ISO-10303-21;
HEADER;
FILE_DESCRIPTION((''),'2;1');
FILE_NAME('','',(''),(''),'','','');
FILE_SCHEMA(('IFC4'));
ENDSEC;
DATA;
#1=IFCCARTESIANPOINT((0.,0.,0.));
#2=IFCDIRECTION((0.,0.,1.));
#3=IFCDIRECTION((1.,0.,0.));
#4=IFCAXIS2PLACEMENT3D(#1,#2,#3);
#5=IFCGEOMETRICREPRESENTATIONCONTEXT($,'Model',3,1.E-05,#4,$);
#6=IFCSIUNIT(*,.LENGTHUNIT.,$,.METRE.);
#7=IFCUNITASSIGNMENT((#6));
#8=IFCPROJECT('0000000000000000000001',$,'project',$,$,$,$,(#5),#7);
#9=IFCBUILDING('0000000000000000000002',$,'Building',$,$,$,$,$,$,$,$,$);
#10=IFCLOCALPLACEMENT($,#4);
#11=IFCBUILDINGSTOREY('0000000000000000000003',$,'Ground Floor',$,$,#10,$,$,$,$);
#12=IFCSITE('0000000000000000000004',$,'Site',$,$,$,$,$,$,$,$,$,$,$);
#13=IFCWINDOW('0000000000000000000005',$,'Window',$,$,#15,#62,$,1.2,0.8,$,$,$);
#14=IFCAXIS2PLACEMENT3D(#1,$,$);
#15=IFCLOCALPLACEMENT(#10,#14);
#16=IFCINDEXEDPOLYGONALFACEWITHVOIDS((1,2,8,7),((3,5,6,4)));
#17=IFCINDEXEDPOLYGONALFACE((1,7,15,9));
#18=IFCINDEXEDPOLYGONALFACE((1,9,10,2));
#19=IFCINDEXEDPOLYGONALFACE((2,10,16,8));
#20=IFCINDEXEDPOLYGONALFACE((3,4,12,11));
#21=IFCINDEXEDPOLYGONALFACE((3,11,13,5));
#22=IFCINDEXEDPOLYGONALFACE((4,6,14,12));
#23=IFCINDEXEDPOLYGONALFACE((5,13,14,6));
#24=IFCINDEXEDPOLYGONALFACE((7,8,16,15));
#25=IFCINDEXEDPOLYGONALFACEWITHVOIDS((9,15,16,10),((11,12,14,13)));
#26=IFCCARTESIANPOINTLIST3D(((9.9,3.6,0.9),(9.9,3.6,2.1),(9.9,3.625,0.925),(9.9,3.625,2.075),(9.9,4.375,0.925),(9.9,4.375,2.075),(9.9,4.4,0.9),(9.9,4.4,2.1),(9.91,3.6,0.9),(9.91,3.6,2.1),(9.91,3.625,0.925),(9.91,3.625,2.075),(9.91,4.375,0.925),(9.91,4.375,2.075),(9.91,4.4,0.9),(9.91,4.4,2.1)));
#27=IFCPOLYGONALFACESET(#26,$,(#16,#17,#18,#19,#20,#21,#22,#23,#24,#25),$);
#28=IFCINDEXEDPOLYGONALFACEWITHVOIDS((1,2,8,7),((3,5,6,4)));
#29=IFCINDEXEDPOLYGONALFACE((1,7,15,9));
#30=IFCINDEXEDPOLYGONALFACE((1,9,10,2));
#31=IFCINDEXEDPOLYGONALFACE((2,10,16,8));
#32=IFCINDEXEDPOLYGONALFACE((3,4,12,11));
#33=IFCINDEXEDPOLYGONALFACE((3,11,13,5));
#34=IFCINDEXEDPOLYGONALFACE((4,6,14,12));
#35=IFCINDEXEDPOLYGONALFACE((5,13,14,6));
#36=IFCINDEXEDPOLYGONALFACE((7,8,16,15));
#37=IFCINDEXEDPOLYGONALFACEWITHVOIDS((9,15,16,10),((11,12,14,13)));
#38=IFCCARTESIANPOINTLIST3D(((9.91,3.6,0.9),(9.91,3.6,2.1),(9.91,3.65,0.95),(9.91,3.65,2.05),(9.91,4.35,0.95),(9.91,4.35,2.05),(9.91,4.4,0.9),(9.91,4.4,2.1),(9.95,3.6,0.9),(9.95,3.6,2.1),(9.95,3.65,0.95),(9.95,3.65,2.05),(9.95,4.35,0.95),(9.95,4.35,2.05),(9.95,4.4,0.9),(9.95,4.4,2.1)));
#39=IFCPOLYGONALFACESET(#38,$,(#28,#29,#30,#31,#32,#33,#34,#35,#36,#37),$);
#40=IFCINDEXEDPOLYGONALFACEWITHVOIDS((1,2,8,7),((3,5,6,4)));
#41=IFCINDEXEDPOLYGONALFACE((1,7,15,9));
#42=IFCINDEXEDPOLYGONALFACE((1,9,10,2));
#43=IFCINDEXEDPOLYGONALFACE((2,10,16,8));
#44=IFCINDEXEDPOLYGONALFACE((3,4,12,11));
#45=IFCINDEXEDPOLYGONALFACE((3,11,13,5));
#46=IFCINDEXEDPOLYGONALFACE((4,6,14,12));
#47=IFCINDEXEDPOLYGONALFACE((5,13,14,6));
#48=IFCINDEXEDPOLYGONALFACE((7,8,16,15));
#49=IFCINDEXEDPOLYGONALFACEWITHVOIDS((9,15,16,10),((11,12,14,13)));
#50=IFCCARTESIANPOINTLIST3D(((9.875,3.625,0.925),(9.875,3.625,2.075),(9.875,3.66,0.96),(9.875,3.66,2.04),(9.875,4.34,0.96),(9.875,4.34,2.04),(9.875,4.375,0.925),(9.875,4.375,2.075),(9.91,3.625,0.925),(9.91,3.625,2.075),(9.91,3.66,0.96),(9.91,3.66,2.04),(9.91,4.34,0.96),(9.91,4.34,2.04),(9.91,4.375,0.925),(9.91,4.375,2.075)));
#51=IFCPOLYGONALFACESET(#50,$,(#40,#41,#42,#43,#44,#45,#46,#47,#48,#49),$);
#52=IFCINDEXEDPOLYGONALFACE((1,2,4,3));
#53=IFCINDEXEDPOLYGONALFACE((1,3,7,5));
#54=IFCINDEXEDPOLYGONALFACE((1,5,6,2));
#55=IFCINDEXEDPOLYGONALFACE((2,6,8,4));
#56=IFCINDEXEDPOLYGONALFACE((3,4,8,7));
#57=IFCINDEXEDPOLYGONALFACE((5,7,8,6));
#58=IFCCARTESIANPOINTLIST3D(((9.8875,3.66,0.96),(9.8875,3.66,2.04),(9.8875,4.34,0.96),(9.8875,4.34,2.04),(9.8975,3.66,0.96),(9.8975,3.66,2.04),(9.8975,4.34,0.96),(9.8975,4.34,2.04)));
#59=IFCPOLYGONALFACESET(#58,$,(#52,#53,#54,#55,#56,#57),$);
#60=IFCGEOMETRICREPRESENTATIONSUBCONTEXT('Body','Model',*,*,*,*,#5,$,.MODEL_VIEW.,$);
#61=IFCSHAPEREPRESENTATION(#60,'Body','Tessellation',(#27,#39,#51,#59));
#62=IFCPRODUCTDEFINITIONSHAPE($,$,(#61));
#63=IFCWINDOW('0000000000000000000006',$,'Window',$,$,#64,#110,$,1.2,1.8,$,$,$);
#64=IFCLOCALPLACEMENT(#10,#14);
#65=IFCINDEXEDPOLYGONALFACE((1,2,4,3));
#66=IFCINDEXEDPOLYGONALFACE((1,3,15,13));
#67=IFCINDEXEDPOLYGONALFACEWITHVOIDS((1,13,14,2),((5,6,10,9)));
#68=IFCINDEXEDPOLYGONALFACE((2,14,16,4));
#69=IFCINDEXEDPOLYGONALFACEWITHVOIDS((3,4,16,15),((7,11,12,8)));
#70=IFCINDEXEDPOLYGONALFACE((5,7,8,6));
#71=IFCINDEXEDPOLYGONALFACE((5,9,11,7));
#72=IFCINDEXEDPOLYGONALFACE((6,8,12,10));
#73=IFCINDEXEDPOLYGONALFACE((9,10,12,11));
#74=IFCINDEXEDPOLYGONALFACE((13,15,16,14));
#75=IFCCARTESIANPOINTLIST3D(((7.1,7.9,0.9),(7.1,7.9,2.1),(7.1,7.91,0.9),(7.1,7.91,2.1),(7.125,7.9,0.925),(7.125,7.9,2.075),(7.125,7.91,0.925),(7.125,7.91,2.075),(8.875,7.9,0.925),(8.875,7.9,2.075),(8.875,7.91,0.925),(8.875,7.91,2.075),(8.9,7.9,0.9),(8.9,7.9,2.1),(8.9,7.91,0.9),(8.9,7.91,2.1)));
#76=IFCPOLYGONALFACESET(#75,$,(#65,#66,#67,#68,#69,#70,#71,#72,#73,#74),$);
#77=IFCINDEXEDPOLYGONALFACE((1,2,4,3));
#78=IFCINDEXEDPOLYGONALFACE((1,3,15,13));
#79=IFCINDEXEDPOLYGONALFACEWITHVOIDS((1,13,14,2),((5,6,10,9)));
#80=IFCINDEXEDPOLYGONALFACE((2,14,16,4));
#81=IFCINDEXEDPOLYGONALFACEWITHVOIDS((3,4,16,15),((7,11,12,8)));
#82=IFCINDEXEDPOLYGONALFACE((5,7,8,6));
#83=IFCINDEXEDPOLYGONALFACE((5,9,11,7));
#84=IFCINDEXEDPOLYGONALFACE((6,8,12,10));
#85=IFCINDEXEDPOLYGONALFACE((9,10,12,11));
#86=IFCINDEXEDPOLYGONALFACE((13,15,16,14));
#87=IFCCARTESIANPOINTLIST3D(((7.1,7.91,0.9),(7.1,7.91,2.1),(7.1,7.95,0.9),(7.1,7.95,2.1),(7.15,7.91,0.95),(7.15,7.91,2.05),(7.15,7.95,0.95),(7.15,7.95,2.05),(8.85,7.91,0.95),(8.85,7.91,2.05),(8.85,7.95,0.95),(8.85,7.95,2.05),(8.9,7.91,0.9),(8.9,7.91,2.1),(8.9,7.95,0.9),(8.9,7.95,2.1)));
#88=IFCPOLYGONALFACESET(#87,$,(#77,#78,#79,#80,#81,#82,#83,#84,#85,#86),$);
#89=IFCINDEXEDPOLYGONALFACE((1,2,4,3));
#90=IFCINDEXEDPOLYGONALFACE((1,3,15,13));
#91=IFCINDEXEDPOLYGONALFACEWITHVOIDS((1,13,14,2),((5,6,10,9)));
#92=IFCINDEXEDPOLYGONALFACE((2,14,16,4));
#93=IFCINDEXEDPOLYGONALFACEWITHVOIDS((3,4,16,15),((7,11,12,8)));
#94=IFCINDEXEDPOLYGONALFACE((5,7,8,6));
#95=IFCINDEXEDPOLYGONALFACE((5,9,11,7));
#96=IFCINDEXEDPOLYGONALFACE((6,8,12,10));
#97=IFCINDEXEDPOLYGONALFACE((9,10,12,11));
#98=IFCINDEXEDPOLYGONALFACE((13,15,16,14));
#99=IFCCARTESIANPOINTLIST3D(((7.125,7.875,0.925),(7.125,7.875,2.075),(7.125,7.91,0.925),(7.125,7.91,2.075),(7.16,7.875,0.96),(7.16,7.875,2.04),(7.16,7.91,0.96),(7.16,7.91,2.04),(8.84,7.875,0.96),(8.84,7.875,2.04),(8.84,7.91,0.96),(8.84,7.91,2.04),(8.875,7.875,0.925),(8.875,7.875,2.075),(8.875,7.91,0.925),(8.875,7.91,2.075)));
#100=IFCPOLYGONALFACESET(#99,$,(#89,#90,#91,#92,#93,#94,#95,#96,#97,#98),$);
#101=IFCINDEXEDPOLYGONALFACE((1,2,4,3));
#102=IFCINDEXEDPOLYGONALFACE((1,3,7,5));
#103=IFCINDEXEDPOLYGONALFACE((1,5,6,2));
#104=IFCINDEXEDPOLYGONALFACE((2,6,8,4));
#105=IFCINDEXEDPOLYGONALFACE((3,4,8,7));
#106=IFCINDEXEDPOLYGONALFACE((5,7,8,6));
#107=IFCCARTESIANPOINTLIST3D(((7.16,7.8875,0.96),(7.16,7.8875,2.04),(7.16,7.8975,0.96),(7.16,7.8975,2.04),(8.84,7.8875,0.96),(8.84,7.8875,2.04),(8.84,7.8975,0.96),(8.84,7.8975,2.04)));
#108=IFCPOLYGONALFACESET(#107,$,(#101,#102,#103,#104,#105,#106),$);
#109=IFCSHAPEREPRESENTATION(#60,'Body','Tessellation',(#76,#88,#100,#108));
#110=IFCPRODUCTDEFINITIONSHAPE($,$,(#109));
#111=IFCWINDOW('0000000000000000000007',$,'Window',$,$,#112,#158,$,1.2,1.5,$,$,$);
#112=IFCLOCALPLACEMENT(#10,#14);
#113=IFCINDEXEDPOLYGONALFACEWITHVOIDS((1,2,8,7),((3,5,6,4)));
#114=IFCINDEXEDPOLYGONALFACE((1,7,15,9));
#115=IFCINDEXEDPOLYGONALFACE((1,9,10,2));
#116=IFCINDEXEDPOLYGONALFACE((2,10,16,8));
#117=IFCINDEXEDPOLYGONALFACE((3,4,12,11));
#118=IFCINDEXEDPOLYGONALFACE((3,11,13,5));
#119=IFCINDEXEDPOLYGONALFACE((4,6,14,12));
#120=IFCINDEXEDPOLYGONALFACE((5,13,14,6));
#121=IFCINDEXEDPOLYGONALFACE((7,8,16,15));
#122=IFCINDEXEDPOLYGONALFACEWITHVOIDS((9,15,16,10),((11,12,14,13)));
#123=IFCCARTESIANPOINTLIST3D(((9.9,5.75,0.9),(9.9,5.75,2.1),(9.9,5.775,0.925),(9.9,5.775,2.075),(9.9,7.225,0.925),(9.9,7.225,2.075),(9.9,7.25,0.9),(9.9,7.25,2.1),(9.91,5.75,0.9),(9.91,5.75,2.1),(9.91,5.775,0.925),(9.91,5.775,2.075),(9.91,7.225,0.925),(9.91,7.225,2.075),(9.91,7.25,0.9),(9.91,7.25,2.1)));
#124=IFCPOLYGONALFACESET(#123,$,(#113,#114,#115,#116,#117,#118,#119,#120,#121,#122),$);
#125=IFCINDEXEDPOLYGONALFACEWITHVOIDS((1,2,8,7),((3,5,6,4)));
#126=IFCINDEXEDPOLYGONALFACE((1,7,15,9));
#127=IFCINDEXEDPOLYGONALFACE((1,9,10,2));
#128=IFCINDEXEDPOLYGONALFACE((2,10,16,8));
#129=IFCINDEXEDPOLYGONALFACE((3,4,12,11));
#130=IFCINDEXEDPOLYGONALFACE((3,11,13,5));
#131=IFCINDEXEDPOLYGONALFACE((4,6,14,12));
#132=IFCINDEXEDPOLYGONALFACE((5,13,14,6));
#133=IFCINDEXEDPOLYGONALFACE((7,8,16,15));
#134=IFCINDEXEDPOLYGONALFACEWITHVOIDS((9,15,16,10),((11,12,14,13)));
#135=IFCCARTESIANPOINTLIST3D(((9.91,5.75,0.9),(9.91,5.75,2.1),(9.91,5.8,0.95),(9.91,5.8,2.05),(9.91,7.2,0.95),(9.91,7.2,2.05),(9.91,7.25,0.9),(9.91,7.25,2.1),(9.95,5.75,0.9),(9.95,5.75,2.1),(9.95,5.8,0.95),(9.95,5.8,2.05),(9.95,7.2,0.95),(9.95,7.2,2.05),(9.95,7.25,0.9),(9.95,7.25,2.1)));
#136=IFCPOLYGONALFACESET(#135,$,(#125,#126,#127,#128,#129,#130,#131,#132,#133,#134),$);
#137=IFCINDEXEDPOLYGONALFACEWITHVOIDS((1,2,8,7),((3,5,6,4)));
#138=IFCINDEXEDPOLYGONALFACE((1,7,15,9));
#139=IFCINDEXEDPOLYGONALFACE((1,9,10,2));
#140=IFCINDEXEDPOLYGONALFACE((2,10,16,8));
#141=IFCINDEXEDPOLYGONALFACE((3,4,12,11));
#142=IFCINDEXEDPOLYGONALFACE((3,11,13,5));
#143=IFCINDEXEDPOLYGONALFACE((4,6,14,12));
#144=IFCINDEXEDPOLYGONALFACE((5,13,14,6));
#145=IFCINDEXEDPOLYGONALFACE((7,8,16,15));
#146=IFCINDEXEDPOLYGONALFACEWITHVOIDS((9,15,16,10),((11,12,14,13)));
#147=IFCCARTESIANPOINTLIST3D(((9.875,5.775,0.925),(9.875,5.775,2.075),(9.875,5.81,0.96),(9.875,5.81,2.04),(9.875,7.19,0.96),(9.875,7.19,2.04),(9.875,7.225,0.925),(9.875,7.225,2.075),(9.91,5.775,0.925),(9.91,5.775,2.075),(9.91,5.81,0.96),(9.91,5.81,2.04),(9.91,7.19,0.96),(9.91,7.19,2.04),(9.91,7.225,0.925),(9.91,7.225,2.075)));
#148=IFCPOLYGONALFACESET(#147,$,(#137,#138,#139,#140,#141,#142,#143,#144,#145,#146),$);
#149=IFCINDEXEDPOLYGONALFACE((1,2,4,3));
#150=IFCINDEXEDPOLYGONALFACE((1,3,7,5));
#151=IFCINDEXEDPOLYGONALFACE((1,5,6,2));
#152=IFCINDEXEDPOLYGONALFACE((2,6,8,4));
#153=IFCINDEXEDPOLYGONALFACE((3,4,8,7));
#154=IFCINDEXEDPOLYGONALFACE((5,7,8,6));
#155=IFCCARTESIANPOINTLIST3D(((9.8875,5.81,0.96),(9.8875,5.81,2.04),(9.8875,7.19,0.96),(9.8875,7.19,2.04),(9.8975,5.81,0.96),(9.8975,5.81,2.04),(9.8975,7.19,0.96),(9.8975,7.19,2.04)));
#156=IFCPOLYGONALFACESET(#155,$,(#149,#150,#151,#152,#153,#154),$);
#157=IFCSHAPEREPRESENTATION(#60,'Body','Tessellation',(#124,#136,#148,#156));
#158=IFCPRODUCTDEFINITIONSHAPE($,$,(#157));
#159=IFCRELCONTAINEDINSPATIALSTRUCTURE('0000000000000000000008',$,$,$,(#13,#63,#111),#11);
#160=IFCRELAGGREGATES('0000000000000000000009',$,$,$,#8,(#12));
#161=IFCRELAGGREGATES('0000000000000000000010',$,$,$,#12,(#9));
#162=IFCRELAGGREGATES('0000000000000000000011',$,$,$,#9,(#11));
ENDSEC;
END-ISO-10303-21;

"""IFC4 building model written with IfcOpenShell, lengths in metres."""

from ifc_helpers import new_model, si_unit, frame, origin_with_axes, place, context, subcontext, project, spatial, line, indexed_curve, outline, extrude, element, save


model = new_model("IFC4")

# Units and contexts
model_context = context("Model", 3, precision=1e-05, world=origin_with_axes())
body_context = subcontext(model_context, "Body", "Model", "MODEL_VIEW")
ifc_project = project(units=[si_unit("LENGTHUNIT", "METRE")], contexts=[model_context])

# Site, building, storey
site = spatial("IfcSite", under=ifc_project, Name="Site")
building = spatial("IfcBuilding", under=site, Name="Building")
storey_placement = place(None, origin_with_axes())
storey = spatial("IfcBuildingStorey", under=building, at=storey_placement, Name="Ground Floor")

# Windows
window_1_placement = place(storey_placement, frame((10.0, 3.6, 0.9), z_axis=(0.0, 0.0, 1.0), x_axis=(0.0, 1.0, 0.0)))
element("IfcWindow", 1, at=window_1_placement, inside=storey, Name="Window", OverallHeight=1.2, OverallWidth=0.8, context=body_context, shape_type="SweptSolid", body=[
    extrude(outline(indexed_curve([(0.0, 0.0), (0.8, 0.0), (0.8, 1.2), (0.0, 1.2)], segments=[line(1, 2, 3, 4, 1)]), holes=[indexed_curve([(0.025, 0.025), (0.775, 0.025), (0.775, 1.175), (0.025, 1.175)], segments=[line(1, 2, 3, 4, 1)])]), frame((0.0, 0.09, 0.0), z_axis=(0.0, -1.0, 0.0), x_axis=(1.0, 0.0, 0.0)), (0.0, 0.0, -1.0), 0.01),
    extrude(outline(indexed_curve([(0.0, 0.0), (0.8, 0.0), (0.8, 1.2), (0.0, 1.2)], segments=[line(1, 2, 3, 4, 1)]), holes=[indexed_curve([(0.05, 0.05), (0.75, 0.05), (0.75, 1.15), (0.05, 1.15)], segments=[line(1, 2, 3, 4, 1)])]), frame((0.0, 0.05, 0.0), z_axis=(0.0, -1.0, 0.0), x_axis=(1.0, 0.0, 0.0)), (0.0, 0.0, -1.0), 0.04),
    extrude(outline(indexed_curve([(0.0, 0.0), (0.75, 0.0), (0.75, 1.15), (0.0, 1.15)], segments=[line(1, 2, 3, 4, 1)]), holes=[indexed_curve([(0.035, 0.035), (0.715, 0.035), (0.715, 1.115), (0.035, 1.115)], segments=[line(1, 2, 3, 4, 1)])]), frame((0.025, 0.09, 0.025), z_axis=(0.0, -1.0, 0.0), x_axis=(1.0, 0.0, 0.0)), (0.0, 0.0, -1.0), 0.035),
    extrude(outline(indexed_curve([(0.035, 0.035), (0.715, 0.035), (0.715, 1.115), (0.035, 1.115)], segments=[line(1, 2, 3, 4, 1)])), frame((0.025, 0.1025, 0.025), z_axis=(0.0, -1.0, 0.0), x_axis=(1.0, 0.0, 0.0)), (0.0, 0.0, -1.0), 0.01),
])
window_2_placement = place(storey_placement, frame((8.9, 8.0, 0.9), z_axis=(0.0, 0.0, 1.0), x_axis=(-1.0, 0.0, 0.0)))
element("IfcWindow", 2, at=window_2_placement, inside=storey, Name="Window", OverallHeight=1.2, OverallWidth=1.8, context=body_context, shape_type="SweptSolid", body=[
    extrude(outline(indexed_curve([(0.0, 0.0), (1.8, 0.0), (1.8, 1.2), (0.0, 1.2)], segments=[line(1, 2, 3, 4, 1)]), holes=[indexed_curve([(0.025, 0.025), (1.775, 0.025), (1.775, 1.175), (0.025, 1.175)], segments=[line(1, 2, 3, 4, 1)])]), frame((0.0, 0.09, 0.0), z_axis=(0.0, -1.0, 0.0), x_axis=(1.0, 0.0, 0.0)), (0.0, 0.0, -1.0), 0.01),
    extrude(outline(indexed_curve([(0.0, 0.0), (1.8, 0.0), (1.8, 1.2), (0.0, 1.2)], segments=[line(1, 2, 3, 4, 1)]), holes=[indexed_curve([(0.05, 0.05), (1.75, 0.05), (1.75, 1.15), (0.05, 1.15)], segments=[line(1, 2, 3, 4, 1)])]), frame((0.0, 0.05, 0.0), z_axis=(0.0, -1.0, 0.0), x_axis=(1.0, 0.0, 0.0)), (0.0, 0.0, -1.0), 0.04),
    extrude(outline(indexed_curve([(0.0, 0.0), (1.75, 0.0), (1.75, 1.15), (0.0, 1.15)], segments=[line(1, 2, 3, 4, 1)]), holes=[indexed_curve([(0.035, 0.035), (1.715, 0.035), (1.715, 1.115), (0.035, 1.115)], segments=[line(1, 2, 3, 4, 1)])]), frame((0.025, 0.09, 0.025), z_axis=(0.0, -1.0, 0.0), x_axis=(1.0, 0.0, 0.0)), (0.0, 0.0, -1.0), 0.035),
    extrude(outline(indexed_curve([(0.035, 0.035), (1.715, 0.035), (1.715, 1.115), (0.035, 1.115)], segments=[line(1, 2, 3, 4, 1)])), frame((0.025, 0.1025, 0.025), z_axis=(0.0, -1.0, 0.0), x_axis=(1.0, 0.0, 0.0)), (0.0, 0.0, -1.0), 0.01),
])
window_3_placement = place(storey_placement, frame((10.0, 5.75, 0.9), z_axis=(0.0, 0.0, 1.0), x_axis=(0.0, 1.0, 0.0)))
element("IfcWindow", 3, at=window_3_placement, inside=storey, Name="Window", OverallHeight=1.2, OverallWidth=1.5, context=body_context, shape_type="SweptSolid", body=[
    extrude(outline(indexed_curve([(0.0, 0.0), (1.5, 0.0), (1.5, 1.2), (0.0, 1.2)], segments=[line(1, 2, 3, 4, 1)]), holes=[indexed_curve([(0.025, 0.025), (1.475, 0.025), (1.475, 1.175), (0.025, 1.175)], segments=[line(1, 2, 3, 4, 1)])]), frame((0.0, 0.09, 0.0), z_axis=(0.0, -1.0, 0.0), x_axis=(1.0, 0.0, 0.0)), (0.0, 0.0, -1.0), 0.01),
    extrude(outline(indexed_curve([(0.0, 0.0), (1.5, 0.0), (1.5, 1.2), (0.0, 1.2)], segments=[line(1, 2, 3, 4, 1)]), holes=[indexed_curve([(0.05, 0.05), (1.45, 0.05), (1.45, 1.15), (0.05, 1.15)], segments=[line(1, 2, 3, 4, 1)])]), frame((0.0, 0.05, 0.0), z_axis=(0.0, -1.0, 0.0), x_axis=(1.0, 0.0, 0.0)), (0.0, 0.0, -1.0), 0.04),
    extrude(outline(indexed_curve([(0.0, 0.0), (1.45, 0.0), (1.45, 1.15), (0.0, 1.15)], segments=[line(1, 2, 3, 4, 1)]), holes=[indexed_curve([(0.035, 0.035), (1.415, 0.035), (1.415, 1.115), (0.035, 1.115)], segments=[line(1, 2, 3, 4, 1)])]), frame((0.025, 0.09, 0.025), z_axis=(0.0, -1.0, 0.0), x_axis=(1.0, 0.0, 0.0)), (0.0, 0.0, -1.0), 0.035),
    extrude(outline(indexed_curve([(0.035, 0.035), (1.415, 0.035), (1.415, 1.115), (0.035, 1.115)], segments=[line(1, 2, 3, 4, 1)])), frame((0.025, 0.1025, 0.025), z_axis=(0.0, -1.0, 0.0), x_axis=(1.0, 0.0, 0.0)), (0.0, 0.0, -1.0), 0.01),
])

save(model, "model.ifc")
